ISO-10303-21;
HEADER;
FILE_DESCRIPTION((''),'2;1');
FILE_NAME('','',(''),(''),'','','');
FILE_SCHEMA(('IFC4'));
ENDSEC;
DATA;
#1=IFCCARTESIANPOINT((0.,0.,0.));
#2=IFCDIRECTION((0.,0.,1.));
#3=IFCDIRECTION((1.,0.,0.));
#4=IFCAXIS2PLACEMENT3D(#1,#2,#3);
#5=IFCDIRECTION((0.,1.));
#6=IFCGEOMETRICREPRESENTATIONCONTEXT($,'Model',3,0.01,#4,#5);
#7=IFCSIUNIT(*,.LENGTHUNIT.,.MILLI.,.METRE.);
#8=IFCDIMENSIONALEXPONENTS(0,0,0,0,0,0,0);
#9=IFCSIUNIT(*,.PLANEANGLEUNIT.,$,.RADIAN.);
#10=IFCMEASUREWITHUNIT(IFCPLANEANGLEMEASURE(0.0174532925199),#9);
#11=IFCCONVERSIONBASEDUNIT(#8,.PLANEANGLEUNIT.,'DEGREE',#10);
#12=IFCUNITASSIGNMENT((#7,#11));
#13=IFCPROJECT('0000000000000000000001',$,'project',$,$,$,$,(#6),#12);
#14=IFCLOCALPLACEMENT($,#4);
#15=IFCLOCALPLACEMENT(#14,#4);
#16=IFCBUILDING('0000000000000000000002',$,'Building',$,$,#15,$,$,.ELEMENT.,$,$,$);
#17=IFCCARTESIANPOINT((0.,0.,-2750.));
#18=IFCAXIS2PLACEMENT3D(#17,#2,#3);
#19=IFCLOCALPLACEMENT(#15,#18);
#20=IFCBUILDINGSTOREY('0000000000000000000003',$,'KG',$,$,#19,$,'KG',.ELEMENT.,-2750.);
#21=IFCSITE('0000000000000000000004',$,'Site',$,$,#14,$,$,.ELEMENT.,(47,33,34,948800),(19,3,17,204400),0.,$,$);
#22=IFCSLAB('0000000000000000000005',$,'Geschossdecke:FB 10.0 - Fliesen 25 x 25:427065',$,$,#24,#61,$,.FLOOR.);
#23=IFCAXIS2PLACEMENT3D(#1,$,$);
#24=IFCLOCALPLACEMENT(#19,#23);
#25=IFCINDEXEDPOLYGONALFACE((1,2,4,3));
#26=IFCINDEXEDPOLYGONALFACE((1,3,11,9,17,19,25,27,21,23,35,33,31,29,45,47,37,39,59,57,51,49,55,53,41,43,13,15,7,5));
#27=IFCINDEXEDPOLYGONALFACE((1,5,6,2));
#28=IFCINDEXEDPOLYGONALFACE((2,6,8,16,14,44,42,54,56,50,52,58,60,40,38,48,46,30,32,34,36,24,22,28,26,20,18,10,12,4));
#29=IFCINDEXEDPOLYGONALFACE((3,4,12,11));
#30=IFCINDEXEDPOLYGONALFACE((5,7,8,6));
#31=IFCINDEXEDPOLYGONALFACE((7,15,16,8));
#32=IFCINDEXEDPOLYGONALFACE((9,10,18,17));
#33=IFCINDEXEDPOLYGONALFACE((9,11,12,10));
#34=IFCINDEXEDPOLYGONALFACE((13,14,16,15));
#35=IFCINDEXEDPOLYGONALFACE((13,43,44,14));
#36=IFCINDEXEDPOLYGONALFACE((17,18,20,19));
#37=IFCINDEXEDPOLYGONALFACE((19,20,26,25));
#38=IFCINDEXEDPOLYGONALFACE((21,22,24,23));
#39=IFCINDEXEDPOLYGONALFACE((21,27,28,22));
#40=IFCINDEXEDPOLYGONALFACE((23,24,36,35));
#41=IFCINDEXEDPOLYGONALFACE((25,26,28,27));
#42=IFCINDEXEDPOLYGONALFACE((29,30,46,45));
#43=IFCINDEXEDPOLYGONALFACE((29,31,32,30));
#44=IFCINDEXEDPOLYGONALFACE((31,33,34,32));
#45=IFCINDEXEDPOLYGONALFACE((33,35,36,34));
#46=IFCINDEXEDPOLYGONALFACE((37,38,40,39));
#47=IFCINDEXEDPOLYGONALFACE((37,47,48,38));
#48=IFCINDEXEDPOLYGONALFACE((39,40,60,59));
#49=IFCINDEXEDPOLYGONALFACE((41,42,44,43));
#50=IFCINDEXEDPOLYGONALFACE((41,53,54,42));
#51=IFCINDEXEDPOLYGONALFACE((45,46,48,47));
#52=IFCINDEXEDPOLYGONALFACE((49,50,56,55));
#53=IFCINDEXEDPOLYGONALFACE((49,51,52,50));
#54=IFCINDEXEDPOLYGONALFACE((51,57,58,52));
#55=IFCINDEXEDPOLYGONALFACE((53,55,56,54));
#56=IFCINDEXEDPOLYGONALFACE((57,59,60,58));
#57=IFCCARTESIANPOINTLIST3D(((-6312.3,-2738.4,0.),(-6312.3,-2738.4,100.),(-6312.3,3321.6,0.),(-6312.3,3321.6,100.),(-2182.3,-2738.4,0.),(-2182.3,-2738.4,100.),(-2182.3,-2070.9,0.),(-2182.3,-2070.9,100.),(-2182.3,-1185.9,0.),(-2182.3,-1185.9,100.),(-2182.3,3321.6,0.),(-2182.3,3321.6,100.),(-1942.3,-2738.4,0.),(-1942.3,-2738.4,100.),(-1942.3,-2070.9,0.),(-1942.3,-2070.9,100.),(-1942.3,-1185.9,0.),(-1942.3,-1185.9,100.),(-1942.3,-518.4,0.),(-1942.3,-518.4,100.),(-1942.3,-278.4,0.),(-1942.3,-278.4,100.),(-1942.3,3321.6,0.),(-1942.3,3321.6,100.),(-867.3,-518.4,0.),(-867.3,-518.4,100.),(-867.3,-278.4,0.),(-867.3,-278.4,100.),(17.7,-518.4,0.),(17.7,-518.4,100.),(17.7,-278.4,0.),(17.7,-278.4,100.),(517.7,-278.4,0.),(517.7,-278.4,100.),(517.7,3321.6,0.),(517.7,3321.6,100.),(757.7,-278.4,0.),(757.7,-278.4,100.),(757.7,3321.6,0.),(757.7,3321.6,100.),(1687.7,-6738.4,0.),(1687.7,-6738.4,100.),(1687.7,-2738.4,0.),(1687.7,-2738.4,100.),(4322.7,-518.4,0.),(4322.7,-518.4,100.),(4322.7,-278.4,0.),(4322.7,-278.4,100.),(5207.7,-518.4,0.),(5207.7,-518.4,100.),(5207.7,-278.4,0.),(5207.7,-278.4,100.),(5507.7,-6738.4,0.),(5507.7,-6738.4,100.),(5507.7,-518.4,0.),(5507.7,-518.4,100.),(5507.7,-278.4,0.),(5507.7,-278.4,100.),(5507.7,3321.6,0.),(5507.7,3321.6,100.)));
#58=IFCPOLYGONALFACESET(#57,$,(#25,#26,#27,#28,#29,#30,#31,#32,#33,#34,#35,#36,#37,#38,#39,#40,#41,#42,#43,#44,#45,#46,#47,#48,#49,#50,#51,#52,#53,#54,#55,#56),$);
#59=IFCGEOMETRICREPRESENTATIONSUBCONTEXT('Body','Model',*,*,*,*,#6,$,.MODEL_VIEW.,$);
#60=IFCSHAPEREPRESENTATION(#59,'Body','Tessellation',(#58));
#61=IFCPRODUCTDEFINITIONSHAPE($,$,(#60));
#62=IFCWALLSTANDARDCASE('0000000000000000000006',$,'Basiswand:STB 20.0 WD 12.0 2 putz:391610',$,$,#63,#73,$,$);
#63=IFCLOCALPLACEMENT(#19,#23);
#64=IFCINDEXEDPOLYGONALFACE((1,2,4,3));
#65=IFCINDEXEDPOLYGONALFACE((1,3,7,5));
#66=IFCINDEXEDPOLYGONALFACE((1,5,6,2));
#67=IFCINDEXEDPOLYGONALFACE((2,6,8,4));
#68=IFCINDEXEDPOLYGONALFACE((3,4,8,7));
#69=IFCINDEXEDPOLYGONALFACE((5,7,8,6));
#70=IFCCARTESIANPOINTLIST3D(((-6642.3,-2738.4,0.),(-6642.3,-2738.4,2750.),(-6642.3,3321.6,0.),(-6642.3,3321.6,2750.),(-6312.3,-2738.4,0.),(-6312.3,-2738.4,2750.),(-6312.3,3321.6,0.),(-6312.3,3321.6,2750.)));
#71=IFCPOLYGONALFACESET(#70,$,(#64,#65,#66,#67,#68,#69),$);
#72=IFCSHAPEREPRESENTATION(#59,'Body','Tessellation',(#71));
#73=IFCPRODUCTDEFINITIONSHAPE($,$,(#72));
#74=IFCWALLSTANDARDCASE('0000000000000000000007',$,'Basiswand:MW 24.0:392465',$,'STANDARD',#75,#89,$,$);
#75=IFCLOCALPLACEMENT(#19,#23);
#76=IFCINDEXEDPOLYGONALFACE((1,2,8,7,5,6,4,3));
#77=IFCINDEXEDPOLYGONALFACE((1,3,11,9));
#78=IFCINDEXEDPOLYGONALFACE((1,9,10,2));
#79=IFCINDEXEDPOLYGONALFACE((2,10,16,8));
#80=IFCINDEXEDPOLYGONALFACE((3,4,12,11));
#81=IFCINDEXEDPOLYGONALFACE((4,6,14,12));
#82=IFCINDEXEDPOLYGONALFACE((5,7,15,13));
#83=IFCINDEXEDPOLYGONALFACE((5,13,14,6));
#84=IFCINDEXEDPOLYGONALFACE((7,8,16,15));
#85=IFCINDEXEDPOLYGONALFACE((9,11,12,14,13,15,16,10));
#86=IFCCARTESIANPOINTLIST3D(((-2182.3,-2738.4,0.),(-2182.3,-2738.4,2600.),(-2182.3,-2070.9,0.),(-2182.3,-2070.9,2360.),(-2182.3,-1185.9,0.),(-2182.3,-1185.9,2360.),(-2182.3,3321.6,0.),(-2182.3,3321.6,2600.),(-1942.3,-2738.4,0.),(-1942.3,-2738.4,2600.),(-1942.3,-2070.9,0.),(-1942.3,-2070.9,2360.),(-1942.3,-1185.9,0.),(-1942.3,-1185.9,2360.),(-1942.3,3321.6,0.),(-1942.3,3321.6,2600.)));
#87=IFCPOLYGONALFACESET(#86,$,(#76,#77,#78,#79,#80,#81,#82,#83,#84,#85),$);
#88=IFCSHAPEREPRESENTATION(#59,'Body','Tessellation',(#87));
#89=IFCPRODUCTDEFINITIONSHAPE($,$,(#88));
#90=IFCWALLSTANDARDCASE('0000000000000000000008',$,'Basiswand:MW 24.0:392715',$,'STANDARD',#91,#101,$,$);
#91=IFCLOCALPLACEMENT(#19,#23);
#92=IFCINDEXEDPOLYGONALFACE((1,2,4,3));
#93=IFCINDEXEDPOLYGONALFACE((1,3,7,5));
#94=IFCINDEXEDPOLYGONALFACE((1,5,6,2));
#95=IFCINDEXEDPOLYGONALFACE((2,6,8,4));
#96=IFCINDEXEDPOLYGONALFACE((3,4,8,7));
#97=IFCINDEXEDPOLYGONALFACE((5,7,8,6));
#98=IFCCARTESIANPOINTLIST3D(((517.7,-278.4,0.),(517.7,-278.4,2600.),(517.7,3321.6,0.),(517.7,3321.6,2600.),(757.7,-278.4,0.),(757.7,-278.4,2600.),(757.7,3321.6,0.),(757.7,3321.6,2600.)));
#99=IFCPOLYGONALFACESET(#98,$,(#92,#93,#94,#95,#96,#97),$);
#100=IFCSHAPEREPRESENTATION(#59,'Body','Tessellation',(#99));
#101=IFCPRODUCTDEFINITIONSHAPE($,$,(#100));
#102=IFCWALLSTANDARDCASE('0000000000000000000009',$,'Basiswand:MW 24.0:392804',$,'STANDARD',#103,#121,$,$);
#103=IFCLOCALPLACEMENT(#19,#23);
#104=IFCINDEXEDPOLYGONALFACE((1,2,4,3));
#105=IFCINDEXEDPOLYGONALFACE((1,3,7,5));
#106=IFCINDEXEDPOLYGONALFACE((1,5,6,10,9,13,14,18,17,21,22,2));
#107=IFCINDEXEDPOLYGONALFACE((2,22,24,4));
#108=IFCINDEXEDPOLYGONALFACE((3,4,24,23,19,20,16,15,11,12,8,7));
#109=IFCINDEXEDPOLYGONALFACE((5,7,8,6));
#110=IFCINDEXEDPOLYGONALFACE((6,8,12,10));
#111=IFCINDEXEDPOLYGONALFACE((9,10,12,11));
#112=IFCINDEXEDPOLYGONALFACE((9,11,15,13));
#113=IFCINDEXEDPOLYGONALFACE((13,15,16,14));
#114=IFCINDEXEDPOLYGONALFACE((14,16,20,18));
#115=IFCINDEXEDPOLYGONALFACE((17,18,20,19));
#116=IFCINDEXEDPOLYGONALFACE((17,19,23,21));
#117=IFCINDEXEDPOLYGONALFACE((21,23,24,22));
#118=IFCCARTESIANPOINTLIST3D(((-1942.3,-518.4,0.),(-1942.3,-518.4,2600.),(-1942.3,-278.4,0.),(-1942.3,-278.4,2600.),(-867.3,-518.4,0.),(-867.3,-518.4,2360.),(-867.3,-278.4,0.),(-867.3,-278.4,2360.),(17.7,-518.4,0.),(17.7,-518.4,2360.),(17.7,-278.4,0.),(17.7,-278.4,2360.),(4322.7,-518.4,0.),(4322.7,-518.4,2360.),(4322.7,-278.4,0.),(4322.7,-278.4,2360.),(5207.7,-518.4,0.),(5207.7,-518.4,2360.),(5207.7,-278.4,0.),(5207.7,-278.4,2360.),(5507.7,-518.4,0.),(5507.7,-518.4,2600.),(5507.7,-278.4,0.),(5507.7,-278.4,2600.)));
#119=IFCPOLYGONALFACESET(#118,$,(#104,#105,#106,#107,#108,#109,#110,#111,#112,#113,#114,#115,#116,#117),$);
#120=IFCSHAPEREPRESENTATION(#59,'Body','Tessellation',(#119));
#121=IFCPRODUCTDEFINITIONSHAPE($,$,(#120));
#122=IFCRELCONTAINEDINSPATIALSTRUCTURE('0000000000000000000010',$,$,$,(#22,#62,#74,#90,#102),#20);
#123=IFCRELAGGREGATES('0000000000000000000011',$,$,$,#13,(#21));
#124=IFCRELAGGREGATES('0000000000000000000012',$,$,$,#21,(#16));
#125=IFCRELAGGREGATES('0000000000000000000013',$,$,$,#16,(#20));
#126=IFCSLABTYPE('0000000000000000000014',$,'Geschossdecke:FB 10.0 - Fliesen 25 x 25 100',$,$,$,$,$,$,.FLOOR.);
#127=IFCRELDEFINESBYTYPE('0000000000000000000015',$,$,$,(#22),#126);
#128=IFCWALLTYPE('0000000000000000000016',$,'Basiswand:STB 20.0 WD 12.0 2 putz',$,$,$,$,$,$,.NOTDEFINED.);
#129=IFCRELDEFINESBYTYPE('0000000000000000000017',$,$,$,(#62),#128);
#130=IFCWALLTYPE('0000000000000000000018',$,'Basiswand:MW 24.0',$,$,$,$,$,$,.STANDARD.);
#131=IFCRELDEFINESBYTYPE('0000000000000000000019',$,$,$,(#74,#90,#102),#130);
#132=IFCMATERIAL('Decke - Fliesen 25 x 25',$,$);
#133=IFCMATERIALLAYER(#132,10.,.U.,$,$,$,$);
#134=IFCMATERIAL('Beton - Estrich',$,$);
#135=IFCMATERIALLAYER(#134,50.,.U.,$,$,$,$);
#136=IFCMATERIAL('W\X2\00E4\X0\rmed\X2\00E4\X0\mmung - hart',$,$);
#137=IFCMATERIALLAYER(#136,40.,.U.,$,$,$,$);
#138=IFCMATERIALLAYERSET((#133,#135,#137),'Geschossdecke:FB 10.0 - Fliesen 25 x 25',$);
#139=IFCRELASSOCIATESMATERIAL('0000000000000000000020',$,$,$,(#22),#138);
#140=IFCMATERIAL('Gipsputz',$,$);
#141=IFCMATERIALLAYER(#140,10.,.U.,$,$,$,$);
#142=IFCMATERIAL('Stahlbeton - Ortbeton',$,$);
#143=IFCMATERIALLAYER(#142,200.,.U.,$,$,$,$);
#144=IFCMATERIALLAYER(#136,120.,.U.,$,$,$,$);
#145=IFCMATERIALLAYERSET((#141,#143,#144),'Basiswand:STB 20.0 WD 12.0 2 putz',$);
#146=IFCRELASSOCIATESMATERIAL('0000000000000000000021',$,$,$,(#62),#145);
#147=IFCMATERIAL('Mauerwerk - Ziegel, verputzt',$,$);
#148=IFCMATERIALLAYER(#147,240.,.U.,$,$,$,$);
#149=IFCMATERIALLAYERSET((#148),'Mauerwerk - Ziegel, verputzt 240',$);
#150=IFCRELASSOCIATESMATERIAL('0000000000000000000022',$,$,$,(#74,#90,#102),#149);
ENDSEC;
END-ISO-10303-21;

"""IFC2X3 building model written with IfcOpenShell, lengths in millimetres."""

from ifc_helpers import new_model, entity, si_unit, converted_unit, direction, frame, origin_with_axes, place, context, subcontext, project, spatial, polyline, outline, extrude, material, layer, layer_set, layer_usage, type_object, element, save


model = new_model("IFC2X3")

# Units and contexts
model_context = context("Model", 3, precision=0.01, world=origin_with_axes(), true_north=direction((0.0, 1.0)))
body_context = subcontext(model_context, "Body", "Model", "MODEL_VIEW")
ifc_project = project(units=[si_unit("LENGTHUNIT", "METRE", prefix="MILLI"), converted_unit("PLANEANGLEUNIT", "DEGREE", entity("IfcPlaneAngleMeasure", 0.0174532925199), si_unit("PLANEANGLEUNIT", "RADIAN"), dimensions=[0, 0, 0, 0, 0, 0, 0])], contexts=[model_context])

# Site, building, storey
site_placement = place(None, origin_with_axes())
site = spatial("IfcSite", under=ifc_project, at=site_placement, Name="Site", CompositionType="ELEMENT", RefLatitude=(47, 33, 34, 948800), RefLongitude=(19, 3, 17, 204400), RefElevation=0.0)
building_placement = place(site_placement, origin_with_axes())
building = spatial("IfcBuilding", under=site, at=building_placement, Name="Building", CompositionType="ELEMENT")
storey_placement = place(building_placement, frame((0.0, 0.0, -2750.0), z_axis=(0.0, 0.0, 1.0), x_axis=(1.0, 0.0, 0.0)))
storey = spatial("IfcBuildingStorey", under=building, at=storey_placement, Name="KG", LongName="KG", CompositionType="ELEMENT", Elevation=-2750.0)

# Slab
ifc_material_1 = material(Name="Decke - Fliesen 25 x 25")
ifc_layer_1 = layer(ifc_material_1, 10.0, ventilated="UNKNOWN")
ifc_material_2 = material(Name="Beton - Estrich")
ifc_layer_2 = layer(ifc_material_2, 50.0, ventilated="UNKNOWN")
ifc_material_3 = material(Name="Wärmedämmung - hart")
ifc_layer_3 = layer(ifc_material_3, 40.0, ventilated="UNKNOWN")
ifc_layer_set_1 = layer_set([ifc_layer_1, ifc_layer_2, ifc_layer_3], Name="Geschossdecke:FB 10.0 - Fliesen 25 x 25")
ifc_layer_usage_1 = layer_usage(ifc_layer_set_1, "AXIS3", "NEGATIVE", 100.0)
slab_type = type_object("IfcSlabType", Name="Geschossdecke:FB 10.0 - Fliesen 25 x 25 100", PredefinedType="FLOOR")
slab_placement = place(storey_placement, frame((-6312.3, -2738.4, 0.0), z_axis=(0.0, 0.0, 1.0), x_axis=(1.0, 0.0, 0.0)))
element("IfcSlab", 1, at=slab_placement, inside=storey, type_object=slab_type, material=ifc_layer_usage_1, Name="Geschossdecke:FB 10.0 - Fliesen 25 x 25:427065", PredefinedType="FLOOR", context=body_context, shape_type="SweptSolid", body=[
    extrude(outline(polyline([(0.0, 0.0), (4130.0, 0.0), (4130.0, 667.5), (4370.0, 667.5), (4370.0, 0.0), (8000.0, 0.0), (8000.0, -4000.0), (11820.0, -4000.0), (11820.0, 2220.0), (11520.0, 2220.0), (11520.0, 2460.0), (11820.0, 2460.0), (11820.0, 6060.0), (7070.0, 6060.0), (7070.0, 2460.0), (10635.0, 2460.0), (10635.0, 2220.0), (6330.0, 2220.0), (6330.0, 2460.0), (6830.0, 2460.0), (6830.0, 6060.0), (4370.0, 6060.0), (4370.0, 2460.0), (5445.0, 2460.0), (5445.0, 2220.0), (4370.0, 2220.0), (4370.0, 1552.5), (4130.0, 1552.5), (4130.0, 6060.0), (0.0, 6060.0), (0.0, 0.0)])), origin_with_axes(), (0.0, 0.0, 1.0), 100.0),
])

# Wall
ifc_material_4 = material(Name="Gipsputz")
ifc_layer_4 = layer(ifc_material_4, 10.0, ventilated="UNKNOWN")
ifc_material_5 = material(Name="Stahlbeton - Ortbeton")
ifc_layer_5 = layer(ifc_material_5, 200.0, ventilated="UNKNOWN")
ifc_layer_6 = layer(ifc_material_3, 120.0, ventilated="UNKNOWN")
ifc_layer_set_2 = layer_set([ifc_layer_4, ifc_layer_5, ifc_layer_6], Name="Basiswand:STB 20.0 WD 12.0 2 putz")
ifc_layer_usage_2 = layer_usage(ifc_layer_set_2, "AXIS2", "POSITIVE", -165.0)
wall_type_1 = type_object("IfcWallType", Name="Basiswand:STB 20.0 WD 12.0 2 putz", PredefinedType="NOTDEFINED")
wall_1_placement = place(storey_placement, frame((-6477.3, -2738.4, 0.0), z_axis=(0.0, 0.0, 1.0), x_axis=(0.0, 1.0, 0.0)))
element("IfcWallStandardCase", 2, at=wall_1_placement, inside=storey, type_object=wall_type_1, material=ifc_layer_usage_2, Name="Basiswand:STB 20.0 WD 12.0 2 putz:391610", context=body_context, shape_type="SweptSolid", body=[
    extrude(outline(polyline([(0.0, -165.0), (6060.0, -165.0), (6060.0, 165.0), (0.0, 165.0), (0.0, -165.0)])), origin_with_axes(), (0.0, 0.0, 1.0), 2750.0),
])

# Wall, opening
ifc_material_6 = material(Name="Mauerwerk - Ziegel, verputzt")
ifc_layer_7 = layer(ifc_material_6, 240.0, ventilated="UNKNOWN")
ifc_layer_set_3 = layer_set([ifc_layer_7], Name="Mauerwerk - Ziegel, verputzt 240")
ifc_layer_usage_3 = layer_usage(ifc_layer_set_3, "AXIS2", "POSITIVE", -120.0)
wall_type_2 = type_object("IfcWallType", Name="Basiswand:MW 24.0", PredefinedType="STANDARD")
wall_2_placement = place(storey_placement, frame((-2062.3, 3321.6, 0.0), z_axis=(0.0, 0.0, 1.0), x_axis=(0.0, -1.0, 0.0)))
wall_2 = element("IfcWallStandardCase", 3, at=wall_2_placement, inside=storey, type_object=wall_type_2, material=ifc_layer_usage_3, Name="Basiswand:MW 24.0:392465", ObjectType="STANDARD", context=body_context, shape_type="SweptSolid", body=[
    extrude(outline(polyline([(0.0, -120.0), (6060.0, -120.0), (6060.0, 120.0), (0.0, 120.0), (0.0, -120.0)])), origin_with_axes(), (0.0, 0.0, 1.0), 2600.0),
])
opening_1_placement = place(wall_2_placement, frame((4950.0, 0.0, 0.0), z_axis=(0.0, 0.0, 1.0), x_axis=(1.0, 0.0, 0.0)))
element("IfcOpeningElement", 4, at=opening_1_placement, cuts=wall_2, context=body_context, shape_type="SweptSolid", body=[
    extrude(outline(polyline([(-442.5, 0.0), (-442.5, -2360.0), (442.5, -2360.0), (442.5, 0.0), (-442.5, 0.0)])), frame((0.0, 120.0, 0.0), z_axis=(0.0, 1.0, 0.0), x_axis=(1.0, 0.0, 0.0)), (0.0, 0.0, -1.0), 240.0),
])

# Wall
ifc_layer_usage_4 = layer_usage(ifc_layer_set_3, "AXIS2", "POSITIVE", -120.0)
wall_3_placement = place(storey_placement, frame((637.7, 3321.6, 0.0), z_axis=(0.0, 0.0, 1.0), x_axis=(0.0, -1.0, 0.0)))
element("IfcWallStandardCase", 5, at=wall_3_placement, inside=storey, type_object=wall_type_2, material=ifc_layer_usage_4, Name="Basiswand:MW 24.0:392715", ObjectType="STANDARD", context=body_context, shape_type="SweptSolid", body=[
    extrude(outline(polyline([(0.0, -120.0), (3600.0, -120.0), (3600.0, 120.0), (0.0, 120.0), (0.0, -120.0)])), origin_with_axes(), (0.0, 0.0, 1.0), 2600.0),
])

# Wall, openings
ifc_layer_usage_5 = layer_usage(ifc_layer_set_3, "AXIS2", "POSITIVE", -120.0)
wall_4_placement = place(storey_placement, frame((-2062.3, -398.4, 0.0), z_axis=(0.0, 0.0, 1.0), x_axis=(1.0, 0.0, 0.0)))
wall_4 = element("IfcWallStandardCase", 6, at=wall_4_placement, inside=storey, type_object=wall_type_2, material=ifc_layer_usage_5, Name="Basiswand:MW 24.0:392804", ObjectType="STANDARD", context=body_context, shape_type="SweptSolid", body=[
    extrude(outline(polyline([(120.0, -120.0), (7570.0, -120.0), (7570.0, 120.0), (120.0, 120.0), (120.0, -120.0)])), origin_with_axes(), (0.0, 0.0, 1.0), 2600.0),
])
opening_2_placement = place(wall_4_placement, frame((1637.5, 0.0, 0.0), z_axis=(0.0, 0.0, 1.0), x_axis=(1.0, 0.0, 0.0)))
element("IfcOpeningElement", 7, at=opening_2_placement, cuts=wall_4, context=body_context, shape_type="SweptSolid", body=[
    extrude(outline(polyline([(-442.5, -2360.0), (442.5, -2360.0), (442.5, 0.0), (-442.5, 0.0), (-442.5, -2360.0)])), frame((0.0, -120.0, 0.0), z_axis=(0.0, 1.0, 0.0), x_axis=(1.0, 0.0, 0.0)), (0.0, 0.0, 1.0), 240.0),
])
opening_3_placement = place(wall_4_placement, frame((6827.5, 0.0, 0.0), z_axis=(0.0, 0.0, 1.0), x_axis=(1.0, 0.0, 0.0)))
element("IfcOpeningElement", 8, at=opening_3_placement, cuts=wall_4, context=body_context, shape_type="SweptSolid", body=[
    extrude(outline(polyline([(-442.5, -2360.0), (442.5, -2360.0), (442.5, 0.0), (-442.5, 0.0), (-442.5, -2360.0)])), frame((0.0, -120.0, 0.0), z_axis=(0.0, 1.0, 0.0), x_axis=(1.0, 0.0, 0.0)), (0.0, 0.0, 1.0), 240.0),
])

save(model, "model.ifc")
